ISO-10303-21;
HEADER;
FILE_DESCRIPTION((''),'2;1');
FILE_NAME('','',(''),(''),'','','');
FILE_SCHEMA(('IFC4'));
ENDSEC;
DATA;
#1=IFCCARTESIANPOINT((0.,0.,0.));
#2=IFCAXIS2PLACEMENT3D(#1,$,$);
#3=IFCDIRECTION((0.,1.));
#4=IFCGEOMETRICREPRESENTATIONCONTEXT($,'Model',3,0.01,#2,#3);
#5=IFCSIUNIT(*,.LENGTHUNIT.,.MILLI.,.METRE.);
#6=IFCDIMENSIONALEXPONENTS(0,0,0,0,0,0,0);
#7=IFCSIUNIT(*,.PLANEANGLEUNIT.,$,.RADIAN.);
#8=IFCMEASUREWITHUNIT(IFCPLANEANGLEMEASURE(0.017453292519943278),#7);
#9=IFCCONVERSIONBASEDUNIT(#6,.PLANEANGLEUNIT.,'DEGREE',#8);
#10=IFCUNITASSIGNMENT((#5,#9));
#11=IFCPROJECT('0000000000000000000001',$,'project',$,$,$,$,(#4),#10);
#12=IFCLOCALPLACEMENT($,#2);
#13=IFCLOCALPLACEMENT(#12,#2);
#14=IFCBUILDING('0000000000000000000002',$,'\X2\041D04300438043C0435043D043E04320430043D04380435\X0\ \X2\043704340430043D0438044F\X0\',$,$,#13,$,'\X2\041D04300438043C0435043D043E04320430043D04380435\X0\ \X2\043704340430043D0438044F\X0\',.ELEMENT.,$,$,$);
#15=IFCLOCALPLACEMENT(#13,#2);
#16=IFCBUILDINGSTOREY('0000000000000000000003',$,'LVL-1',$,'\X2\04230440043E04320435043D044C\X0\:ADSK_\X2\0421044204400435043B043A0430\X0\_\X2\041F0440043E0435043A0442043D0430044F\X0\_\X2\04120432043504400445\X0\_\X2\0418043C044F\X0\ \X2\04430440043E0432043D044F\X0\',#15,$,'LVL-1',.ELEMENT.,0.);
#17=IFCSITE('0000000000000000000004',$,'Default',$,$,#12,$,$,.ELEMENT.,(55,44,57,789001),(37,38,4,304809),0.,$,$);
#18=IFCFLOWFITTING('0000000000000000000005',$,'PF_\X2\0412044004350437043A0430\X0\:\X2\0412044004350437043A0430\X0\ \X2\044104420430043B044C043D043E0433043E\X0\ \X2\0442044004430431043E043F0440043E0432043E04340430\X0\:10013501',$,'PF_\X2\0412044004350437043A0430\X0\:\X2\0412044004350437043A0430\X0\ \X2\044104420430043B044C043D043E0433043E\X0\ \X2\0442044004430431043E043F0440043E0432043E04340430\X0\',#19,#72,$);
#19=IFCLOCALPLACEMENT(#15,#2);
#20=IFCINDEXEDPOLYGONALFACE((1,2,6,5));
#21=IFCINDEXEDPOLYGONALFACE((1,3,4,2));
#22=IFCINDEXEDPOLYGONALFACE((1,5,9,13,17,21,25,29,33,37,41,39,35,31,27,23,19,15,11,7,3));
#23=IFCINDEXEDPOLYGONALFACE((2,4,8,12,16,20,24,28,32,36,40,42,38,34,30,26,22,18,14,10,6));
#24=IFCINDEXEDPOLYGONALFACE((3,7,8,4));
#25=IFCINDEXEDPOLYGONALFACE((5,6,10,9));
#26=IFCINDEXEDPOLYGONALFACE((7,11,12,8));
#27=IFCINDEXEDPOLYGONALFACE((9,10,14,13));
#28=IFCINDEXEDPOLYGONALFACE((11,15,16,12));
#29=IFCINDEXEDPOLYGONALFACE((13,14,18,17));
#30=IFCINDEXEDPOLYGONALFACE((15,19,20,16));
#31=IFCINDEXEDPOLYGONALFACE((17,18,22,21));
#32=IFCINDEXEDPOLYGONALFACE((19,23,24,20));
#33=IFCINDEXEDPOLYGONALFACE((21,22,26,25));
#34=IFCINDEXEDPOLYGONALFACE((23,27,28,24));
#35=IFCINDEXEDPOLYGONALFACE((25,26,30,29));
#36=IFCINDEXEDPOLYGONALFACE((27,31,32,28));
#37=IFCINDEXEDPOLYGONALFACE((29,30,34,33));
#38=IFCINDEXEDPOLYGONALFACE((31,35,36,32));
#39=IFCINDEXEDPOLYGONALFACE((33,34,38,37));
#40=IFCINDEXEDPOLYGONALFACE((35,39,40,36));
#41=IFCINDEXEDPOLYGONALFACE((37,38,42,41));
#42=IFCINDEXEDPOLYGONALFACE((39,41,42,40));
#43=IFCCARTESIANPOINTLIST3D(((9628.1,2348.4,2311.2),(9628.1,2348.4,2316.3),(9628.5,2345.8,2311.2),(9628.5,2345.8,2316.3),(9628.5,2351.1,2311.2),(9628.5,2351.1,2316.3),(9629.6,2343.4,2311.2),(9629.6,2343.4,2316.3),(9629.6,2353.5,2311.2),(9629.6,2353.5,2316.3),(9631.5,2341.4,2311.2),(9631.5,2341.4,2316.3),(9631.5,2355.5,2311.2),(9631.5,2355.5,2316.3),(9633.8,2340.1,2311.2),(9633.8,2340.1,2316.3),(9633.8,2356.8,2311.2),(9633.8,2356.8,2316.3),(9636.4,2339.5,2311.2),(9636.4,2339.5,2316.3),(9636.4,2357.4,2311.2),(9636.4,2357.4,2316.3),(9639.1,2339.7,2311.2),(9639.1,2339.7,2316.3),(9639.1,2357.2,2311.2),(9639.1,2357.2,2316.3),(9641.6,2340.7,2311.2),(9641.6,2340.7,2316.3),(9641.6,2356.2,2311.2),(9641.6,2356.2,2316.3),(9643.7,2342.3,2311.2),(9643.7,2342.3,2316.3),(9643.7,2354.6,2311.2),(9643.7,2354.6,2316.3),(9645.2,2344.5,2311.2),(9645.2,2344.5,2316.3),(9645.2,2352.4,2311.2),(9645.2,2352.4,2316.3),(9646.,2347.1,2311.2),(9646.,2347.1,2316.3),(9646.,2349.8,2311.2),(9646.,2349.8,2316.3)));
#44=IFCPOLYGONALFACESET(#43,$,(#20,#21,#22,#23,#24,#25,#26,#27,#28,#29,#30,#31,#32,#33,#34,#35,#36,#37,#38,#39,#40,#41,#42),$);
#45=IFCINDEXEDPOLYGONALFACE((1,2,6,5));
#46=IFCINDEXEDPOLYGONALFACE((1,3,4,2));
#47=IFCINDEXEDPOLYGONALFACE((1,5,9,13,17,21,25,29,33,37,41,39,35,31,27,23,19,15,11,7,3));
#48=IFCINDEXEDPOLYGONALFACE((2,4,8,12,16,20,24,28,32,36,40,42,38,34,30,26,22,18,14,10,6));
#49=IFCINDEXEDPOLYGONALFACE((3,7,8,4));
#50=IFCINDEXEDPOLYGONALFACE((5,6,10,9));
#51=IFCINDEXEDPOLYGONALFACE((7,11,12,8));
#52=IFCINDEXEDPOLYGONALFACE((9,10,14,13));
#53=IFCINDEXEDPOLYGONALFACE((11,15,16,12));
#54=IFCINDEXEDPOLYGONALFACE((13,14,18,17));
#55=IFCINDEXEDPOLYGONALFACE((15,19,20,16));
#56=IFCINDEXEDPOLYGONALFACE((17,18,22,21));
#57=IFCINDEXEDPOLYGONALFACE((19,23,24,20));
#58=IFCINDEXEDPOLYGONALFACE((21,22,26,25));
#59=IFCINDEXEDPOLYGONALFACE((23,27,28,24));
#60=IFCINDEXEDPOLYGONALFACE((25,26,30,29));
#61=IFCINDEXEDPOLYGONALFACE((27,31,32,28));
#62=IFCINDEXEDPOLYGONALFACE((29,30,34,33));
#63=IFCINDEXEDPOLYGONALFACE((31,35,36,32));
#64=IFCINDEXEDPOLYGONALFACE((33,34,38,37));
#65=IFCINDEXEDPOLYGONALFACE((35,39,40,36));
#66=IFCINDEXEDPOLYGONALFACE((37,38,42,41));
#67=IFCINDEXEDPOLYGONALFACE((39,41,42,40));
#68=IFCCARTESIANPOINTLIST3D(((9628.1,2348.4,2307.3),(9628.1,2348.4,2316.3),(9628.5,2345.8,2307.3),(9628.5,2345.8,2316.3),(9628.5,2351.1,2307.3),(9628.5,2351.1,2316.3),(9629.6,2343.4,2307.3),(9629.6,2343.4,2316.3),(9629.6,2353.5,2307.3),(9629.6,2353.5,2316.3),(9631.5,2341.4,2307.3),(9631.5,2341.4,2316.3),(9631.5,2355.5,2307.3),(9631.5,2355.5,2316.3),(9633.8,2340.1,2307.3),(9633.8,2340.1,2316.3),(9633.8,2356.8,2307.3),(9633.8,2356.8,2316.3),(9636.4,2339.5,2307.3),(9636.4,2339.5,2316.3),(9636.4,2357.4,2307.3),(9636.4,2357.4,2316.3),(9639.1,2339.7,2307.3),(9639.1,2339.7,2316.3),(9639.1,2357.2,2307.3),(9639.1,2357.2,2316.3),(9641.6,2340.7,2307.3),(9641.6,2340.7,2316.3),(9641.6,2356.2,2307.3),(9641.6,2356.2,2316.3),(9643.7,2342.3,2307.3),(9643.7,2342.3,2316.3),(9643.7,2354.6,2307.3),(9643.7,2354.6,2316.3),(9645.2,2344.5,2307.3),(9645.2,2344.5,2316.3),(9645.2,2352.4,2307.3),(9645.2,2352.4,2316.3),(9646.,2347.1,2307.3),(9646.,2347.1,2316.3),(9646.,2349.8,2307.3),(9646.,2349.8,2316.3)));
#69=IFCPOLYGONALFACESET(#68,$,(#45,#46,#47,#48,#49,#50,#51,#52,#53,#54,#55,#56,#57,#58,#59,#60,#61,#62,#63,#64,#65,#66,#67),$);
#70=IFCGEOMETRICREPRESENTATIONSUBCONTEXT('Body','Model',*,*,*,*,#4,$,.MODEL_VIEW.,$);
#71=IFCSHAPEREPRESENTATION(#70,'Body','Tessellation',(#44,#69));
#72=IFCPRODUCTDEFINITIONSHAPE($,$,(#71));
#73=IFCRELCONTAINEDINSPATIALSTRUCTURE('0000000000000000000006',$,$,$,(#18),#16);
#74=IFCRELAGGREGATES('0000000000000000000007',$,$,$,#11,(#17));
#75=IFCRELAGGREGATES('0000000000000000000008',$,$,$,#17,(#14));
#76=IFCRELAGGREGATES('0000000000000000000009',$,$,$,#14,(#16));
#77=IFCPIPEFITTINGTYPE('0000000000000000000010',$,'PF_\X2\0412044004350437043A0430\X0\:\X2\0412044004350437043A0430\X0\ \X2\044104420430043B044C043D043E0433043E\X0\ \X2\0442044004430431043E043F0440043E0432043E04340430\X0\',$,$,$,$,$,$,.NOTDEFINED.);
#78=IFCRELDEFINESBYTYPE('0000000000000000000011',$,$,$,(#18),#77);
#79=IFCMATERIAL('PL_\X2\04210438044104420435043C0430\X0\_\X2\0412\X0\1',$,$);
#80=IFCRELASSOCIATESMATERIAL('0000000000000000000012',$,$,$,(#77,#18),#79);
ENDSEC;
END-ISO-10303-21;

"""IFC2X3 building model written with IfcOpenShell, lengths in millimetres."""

from ifc_helpers import new_model, entity, si_unit, converted_unit, direction, frame, frame_2d, origin, place, context, subcontext, project, spatial, circle, extrude, source, transform, mapped, material, type_object, type_shapes, element, save


model = new_model("IFC2X3")

# Units and contexts
model_context = context("Model", 3, precision=0.01, world=origin(), true_north=direction((0.0, 1.0)))
body_context = subcontext(model_context, "Body", "Model", "MODEL_VIEW")
ifc_project = project(units=[si_unit("LENGTHUNIT", "METRE", prefix="MILLI"), converted_unit("PLANEANGLEUNIT", "DEGREE", entity("IfcPlaneAngleMeasure", 0.017453292519943278), si_unit("PLANEANGLEUNIT", "RADIAN"), dimensions=[0, 0, 0, 0, 0, 0, 0])], contexts=[model_context])

# Site, building, storey
site_placement = place(None, origin())
site = spatial("IfcSite", under=ifc_project, at=site_placement, Name="Default", CompositionType="ELEMENT", RefLatitude=(55, 44, 57, 789001), RefLongitude=(37, 38, 4, 304809), RefElevation=0.0)
building_placement = place(site_placement, origin())
building = spatial("IfcBuilding", under=site, at=building_placement, Name="Наименование здания", LongName="Наименование здания", CompositionType="ELEMENT")
storey_placement = place(building_placement, origin())
storey = spatial("IfcBuildingStorey", under=building, at=storey_placement, Name="LVL-1", ObjectType="Уровень:ADSK_Стрелка_Проектная_Вверх_Имя уровня", LongName="LVL-1", CompositionType="ELEMENT", Elevation=0.0)

# Flow fitting
ifc_material_1 = material(Name="PL_Система_В1")
pipe_fitting_type_1 = type_object("IfcPipeFittingType", Name="PF_Врезка:Врезка стального трубопровода", PredefinedType="NOTDEFINED", material=ifc_material_1)
shared_shape_1 = source(origin(), body_context, "Body", "SweptSolid", [
    extrude(circle(Radius=9.0, at=frame_2d((0.0, 0.0), x_axis=(1.0, 0.0))), frame((-5.1, 0.0, 0.0), z_axis=(1.0, 0.0, 0.0), x_axis=(0.0, 1.0, 0.0)), (0.0, 0.0, 1.0), 5.1),
    extrude(circle(Radius=9.0, at=frame_2d((0.0, 0.0), x_axis=(1.0, 0.0))), frame((-9.0, 0.0, 0.0), z_axis=(1.0, 0.0, 0.0), x_axis=(0.0, 1.0, 0.0)), (0.0, 0.0, 1.0), 9.0),
])
type_shapes(pipe_fitting_type_1, [shared_shape_1])
flow_fitting_1_placement = place(storey_placement, frame((9637.1, 2348.4, 2316.3), z_axis=(0.0, -1.0, 0.0), x_axis=(0.0, 0.0, 1.0)))
element("IfcFlowFitting", 1, at=flow_fitting_1_placement, inside=storey, type_object=pipe_fitting_type_1, material=ifc_material_1, Name="PF_Врезка:Врезка стального трубопровода:10013501", ObjectType="PF_Врезка:Врезка стального трубопровода", context=body_context, shape_type="MappedRepresentation", body=[
    mapped(shared_shape_1, transform((0.0, 0.0, 0.0), scale=1.0)),
])

save(model, "model.ifc")
